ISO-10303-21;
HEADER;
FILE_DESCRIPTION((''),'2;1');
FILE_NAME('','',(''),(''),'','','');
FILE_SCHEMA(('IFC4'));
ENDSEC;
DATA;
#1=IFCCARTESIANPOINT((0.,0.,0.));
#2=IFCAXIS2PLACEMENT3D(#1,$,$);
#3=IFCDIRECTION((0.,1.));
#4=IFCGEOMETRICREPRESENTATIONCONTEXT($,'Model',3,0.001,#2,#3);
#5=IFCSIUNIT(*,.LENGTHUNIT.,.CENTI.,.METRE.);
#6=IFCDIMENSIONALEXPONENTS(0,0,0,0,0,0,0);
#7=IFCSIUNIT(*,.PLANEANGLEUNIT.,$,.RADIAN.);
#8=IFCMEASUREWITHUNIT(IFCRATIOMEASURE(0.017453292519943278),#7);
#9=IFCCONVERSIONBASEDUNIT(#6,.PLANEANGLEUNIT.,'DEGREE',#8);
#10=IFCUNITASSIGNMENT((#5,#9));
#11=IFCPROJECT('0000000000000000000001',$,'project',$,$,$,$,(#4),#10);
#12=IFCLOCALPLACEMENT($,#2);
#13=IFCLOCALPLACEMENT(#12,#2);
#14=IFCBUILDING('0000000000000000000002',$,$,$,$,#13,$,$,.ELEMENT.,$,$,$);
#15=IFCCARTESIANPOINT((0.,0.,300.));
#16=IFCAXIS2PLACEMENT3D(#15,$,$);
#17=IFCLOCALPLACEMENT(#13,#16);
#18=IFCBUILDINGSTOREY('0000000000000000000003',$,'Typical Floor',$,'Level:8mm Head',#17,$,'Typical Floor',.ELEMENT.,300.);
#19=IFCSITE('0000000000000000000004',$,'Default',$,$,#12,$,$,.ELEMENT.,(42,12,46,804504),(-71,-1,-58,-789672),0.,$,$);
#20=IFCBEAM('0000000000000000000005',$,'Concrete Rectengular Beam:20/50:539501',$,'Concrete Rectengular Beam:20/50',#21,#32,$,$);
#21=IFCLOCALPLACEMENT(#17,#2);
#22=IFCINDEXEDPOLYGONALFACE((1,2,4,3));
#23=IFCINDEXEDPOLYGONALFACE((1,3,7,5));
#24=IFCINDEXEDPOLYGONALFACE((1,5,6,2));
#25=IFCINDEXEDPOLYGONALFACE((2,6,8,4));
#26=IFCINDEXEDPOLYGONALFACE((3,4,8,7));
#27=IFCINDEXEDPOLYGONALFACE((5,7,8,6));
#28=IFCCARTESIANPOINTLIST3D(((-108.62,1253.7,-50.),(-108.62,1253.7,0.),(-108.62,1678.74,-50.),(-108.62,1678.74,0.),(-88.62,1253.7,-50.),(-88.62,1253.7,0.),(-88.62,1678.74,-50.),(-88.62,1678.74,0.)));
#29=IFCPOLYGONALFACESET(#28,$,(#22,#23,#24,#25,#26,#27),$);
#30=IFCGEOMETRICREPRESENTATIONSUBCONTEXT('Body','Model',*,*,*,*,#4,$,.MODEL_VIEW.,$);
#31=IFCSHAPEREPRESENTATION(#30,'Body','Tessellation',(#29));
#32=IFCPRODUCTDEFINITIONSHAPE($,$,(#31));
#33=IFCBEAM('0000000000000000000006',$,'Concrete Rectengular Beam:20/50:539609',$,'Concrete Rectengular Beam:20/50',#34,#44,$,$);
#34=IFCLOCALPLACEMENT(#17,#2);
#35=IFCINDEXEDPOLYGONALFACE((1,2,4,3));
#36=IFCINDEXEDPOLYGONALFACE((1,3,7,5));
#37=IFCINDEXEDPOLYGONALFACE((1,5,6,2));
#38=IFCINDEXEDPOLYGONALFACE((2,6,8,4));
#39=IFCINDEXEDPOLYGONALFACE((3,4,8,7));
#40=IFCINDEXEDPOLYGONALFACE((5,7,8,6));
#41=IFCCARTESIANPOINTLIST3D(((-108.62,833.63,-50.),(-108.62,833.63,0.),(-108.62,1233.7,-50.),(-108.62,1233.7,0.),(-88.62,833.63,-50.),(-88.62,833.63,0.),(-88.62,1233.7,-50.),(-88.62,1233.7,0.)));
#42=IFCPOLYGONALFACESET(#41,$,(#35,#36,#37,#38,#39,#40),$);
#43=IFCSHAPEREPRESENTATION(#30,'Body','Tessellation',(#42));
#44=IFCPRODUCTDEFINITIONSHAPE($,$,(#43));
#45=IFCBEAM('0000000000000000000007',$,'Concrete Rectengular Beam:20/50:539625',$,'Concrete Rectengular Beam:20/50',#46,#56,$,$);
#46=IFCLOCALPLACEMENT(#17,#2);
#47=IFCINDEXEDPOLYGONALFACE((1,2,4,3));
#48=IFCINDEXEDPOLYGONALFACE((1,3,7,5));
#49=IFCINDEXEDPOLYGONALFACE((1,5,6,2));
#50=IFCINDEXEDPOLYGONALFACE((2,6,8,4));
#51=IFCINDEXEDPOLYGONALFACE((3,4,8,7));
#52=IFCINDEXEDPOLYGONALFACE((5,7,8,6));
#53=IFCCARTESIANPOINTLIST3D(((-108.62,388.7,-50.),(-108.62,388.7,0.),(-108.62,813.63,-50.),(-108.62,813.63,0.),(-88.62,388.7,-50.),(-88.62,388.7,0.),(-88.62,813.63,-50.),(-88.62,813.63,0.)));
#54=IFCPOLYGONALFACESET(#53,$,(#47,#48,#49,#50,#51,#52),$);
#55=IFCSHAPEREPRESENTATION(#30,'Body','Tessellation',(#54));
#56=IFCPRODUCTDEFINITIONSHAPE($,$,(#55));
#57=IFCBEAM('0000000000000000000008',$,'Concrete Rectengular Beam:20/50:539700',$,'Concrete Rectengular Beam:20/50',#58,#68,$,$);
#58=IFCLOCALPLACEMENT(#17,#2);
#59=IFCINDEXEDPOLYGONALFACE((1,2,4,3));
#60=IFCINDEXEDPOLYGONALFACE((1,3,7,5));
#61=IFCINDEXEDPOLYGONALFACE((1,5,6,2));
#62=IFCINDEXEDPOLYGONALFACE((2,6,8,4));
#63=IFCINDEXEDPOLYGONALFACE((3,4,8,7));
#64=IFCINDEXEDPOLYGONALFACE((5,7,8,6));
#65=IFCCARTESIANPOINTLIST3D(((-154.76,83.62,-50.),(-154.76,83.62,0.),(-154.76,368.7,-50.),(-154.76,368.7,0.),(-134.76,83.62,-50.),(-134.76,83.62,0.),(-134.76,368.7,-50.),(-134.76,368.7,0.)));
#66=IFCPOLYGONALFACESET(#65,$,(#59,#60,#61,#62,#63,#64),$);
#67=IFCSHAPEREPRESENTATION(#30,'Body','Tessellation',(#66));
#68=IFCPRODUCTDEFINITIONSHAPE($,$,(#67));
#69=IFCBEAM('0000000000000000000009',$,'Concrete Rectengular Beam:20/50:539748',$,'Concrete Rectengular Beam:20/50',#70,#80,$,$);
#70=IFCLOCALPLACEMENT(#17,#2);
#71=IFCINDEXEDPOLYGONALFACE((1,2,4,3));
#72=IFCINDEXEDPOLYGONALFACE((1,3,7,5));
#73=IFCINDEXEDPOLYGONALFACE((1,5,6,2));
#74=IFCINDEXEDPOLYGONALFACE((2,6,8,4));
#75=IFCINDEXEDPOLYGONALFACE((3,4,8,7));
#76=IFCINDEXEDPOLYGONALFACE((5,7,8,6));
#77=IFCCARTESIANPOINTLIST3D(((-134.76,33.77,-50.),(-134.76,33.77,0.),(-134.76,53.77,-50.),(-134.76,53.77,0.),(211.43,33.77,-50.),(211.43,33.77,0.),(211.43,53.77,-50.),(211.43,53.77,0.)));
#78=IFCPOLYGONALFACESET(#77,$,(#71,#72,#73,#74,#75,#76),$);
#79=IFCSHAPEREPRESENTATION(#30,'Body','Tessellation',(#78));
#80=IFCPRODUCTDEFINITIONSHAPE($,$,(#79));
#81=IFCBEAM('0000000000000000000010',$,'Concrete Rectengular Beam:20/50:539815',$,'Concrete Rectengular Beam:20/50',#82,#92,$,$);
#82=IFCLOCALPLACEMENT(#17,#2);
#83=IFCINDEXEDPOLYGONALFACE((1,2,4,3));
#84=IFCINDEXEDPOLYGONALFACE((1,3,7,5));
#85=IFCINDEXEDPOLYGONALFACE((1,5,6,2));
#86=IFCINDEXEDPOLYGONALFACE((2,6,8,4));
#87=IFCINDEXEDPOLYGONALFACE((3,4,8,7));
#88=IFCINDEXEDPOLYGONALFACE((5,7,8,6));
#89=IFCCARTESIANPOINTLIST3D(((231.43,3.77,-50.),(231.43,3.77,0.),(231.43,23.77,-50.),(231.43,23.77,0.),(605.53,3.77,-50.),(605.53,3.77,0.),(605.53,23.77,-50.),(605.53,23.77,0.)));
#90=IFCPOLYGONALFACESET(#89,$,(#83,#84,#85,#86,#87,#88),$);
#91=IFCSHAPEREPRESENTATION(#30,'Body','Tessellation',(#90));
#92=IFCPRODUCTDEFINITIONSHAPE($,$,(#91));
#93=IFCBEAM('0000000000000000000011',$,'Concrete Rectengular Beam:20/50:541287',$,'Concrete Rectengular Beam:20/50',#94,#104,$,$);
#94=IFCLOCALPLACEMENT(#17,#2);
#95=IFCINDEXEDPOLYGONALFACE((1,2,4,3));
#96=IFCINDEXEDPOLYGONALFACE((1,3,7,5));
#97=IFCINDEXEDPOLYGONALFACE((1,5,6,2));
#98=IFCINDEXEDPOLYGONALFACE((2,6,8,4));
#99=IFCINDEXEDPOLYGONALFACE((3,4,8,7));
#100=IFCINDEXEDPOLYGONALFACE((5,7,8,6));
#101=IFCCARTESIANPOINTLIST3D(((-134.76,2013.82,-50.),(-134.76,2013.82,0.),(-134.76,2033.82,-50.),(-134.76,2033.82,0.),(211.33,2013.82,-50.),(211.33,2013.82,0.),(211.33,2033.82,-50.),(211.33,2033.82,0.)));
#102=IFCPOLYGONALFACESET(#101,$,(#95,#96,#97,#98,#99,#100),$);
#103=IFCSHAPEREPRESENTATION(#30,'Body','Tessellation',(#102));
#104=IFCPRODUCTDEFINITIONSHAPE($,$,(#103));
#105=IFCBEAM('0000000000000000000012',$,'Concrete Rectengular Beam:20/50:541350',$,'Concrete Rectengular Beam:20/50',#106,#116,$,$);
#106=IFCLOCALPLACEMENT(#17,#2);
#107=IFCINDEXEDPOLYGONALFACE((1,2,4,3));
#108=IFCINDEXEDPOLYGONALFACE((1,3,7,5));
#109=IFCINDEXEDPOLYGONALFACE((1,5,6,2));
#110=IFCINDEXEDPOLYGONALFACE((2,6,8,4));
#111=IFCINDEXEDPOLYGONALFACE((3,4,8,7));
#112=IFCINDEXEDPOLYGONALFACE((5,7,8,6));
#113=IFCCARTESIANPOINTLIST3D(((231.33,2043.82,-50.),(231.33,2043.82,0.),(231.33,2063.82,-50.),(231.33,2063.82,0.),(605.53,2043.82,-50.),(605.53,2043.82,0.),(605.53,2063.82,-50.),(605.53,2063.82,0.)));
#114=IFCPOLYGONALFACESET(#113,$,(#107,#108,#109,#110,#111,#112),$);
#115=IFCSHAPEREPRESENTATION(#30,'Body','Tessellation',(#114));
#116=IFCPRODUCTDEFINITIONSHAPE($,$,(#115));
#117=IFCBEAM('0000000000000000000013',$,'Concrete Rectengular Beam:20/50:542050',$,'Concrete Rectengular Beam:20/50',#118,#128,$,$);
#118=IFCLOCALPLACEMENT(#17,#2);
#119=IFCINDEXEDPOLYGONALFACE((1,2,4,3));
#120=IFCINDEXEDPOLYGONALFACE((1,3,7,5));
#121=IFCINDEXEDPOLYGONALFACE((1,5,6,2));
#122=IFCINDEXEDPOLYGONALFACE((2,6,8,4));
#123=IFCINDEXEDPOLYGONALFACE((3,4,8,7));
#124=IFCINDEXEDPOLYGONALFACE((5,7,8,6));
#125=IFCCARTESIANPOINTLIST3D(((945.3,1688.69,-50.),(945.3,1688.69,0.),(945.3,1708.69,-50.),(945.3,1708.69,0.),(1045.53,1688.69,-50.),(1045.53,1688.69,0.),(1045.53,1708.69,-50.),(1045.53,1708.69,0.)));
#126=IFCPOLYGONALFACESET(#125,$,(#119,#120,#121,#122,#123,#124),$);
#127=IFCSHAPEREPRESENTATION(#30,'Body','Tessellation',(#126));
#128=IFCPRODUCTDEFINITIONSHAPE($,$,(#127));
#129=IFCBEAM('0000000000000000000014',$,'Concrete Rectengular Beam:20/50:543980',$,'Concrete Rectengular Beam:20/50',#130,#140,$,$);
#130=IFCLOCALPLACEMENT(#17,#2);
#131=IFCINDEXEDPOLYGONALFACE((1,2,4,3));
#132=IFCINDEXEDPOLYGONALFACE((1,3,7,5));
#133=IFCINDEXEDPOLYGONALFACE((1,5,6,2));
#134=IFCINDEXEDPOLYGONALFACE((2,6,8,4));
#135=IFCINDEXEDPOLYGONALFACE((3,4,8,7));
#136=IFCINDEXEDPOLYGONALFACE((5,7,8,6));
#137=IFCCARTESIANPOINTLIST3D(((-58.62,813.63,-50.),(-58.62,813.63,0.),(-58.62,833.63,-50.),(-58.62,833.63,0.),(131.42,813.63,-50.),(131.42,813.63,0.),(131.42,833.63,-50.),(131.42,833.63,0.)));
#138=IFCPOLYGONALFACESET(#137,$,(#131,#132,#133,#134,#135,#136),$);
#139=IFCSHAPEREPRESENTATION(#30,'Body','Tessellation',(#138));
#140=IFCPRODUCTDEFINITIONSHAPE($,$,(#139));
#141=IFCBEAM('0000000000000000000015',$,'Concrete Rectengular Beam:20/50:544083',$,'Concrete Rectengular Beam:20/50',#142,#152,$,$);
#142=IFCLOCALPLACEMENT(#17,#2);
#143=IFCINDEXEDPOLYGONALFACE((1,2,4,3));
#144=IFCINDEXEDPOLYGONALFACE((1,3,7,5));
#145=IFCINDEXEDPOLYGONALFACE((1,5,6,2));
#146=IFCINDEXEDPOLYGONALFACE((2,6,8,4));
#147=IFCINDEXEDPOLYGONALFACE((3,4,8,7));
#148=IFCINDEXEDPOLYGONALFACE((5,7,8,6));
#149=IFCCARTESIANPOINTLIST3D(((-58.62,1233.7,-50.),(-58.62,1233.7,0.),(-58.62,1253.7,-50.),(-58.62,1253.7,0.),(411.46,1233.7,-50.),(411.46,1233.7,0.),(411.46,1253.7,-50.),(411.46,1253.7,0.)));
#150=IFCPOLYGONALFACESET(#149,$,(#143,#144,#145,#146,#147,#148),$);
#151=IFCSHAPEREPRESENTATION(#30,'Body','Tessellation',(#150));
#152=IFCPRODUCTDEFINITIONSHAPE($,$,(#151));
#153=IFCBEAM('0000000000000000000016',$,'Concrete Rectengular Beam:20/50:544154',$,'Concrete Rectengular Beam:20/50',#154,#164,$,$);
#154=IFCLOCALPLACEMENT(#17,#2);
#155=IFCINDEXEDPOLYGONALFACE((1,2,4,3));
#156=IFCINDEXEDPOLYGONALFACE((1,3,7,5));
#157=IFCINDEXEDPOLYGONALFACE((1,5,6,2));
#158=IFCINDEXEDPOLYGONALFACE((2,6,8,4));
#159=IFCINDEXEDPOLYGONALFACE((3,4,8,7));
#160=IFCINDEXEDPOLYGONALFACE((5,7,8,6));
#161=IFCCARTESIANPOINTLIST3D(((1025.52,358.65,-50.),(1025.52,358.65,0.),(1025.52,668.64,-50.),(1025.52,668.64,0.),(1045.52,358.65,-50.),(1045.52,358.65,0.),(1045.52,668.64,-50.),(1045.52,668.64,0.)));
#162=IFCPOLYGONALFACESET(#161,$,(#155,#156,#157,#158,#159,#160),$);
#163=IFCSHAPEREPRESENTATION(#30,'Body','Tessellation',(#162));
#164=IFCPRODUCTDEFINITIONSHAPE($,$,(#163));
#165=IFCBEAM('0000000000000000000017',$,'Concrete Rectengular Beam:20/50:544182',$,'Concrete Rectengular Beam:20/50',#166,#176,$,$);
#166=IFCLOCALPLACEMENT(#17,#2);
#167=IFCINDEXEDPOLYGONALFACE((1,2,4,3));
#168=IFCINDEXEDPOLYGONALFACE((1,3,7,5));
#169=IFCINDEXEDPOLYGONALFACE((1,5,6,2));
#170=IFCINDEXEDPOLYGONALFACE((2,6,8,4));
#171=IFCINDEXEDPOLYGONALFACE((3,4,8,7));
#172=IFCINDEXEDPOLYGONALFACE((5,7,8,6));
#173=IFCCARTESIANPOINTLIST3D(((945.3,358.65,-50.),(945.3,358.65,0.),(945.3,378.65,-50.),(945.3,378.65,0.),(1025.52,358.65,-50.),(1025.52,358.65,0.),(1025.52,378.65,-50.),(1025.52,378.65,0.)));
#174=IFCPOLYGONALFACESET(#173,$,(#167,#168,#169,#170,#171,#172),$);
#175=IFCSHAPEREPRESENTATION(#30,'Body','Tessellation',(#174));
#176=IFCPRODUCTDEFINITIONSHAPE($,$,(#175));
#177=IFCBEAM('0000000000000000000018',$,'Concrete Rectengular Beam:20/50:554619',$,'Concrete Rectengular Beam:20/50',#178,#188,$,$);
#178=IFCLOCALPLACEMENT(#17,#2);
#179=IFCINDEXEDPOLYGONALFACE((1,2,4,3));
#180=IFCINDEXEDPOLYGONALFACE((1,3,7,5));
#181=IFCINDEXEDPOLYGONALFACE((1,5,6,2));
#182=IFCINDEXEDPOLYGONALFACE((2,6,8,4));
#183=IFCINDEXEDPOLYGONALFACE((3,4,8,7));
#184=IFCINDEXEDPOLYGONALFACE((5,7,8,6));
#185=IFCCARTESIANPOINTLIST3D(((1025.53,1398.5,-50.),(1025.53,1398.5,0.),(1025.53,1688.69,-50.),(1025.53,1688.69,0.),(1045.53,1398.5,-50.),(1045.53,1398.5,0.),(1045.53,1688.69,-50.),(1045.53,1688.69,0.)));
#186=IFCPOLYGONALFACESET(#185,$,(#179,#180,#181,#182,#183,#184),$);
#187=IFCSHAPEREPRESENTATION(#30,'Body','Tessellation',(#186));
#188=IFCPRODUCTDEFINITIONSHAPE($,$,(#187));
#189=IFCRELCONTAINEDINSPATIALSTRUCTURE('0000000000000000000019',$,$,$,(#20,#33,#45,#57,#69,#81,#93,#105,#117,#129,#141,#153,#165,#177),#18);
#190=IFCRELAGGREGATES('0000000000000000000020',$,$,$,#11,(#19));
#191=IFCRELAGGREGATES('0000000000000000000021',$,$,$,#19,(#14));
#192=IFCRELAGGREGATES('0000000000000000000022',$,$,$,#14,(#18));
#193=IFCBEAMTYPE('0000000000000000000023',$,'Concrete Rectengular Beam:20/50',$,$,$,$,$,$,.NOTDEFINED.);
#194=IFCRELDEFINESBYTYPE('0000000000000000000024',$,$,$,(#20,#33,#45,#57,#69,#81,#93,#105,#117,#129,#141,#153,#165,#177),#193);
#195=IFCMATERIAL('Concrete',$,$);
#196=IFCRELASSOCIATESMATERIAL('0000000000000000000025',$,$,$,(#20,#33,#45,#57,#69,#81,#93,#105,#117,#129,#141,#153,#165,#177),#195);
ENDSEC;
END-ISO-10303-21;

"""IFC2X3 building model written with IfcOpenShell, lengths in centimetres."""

from ifc_helpers import new_model, entity, si_unit, converted_unit, direction, frame, frame_2d, origin, place, context, subcontext, project, spatial, rectangle, extrude, material, type_object, element, save


model = new_model("IFC2X3")

# Units and contexts
model_context = context("Model", 3, precision=0.001, world=origin(), true_north=direction((0.0, 1.0)))
body_context = subcontext(model_context, "Body", "Model", "MODEL_VIEW")
ifc_project = project(units=[si_unit("LENGTHUNIT", "METRE", prefix="CENTI"), converted_unit("PLANEANGLEUNIT", "DEGREE", entity("IfcRatioMeasure", 0.017453292519943278), si_unit("PLANEANGLEUNIT", "RADIAN"), dimensions=[0, 0, 0, 0, 0, 0, 0])], contexts=[model_context])

# Site, building, storey
site_placement = place(None, origin())
site = spatial("IfcSite", under=ifc_project, at=site_placement, Name="Default", CompositionType="ELEMENT", RefLatitude=(42, 12, 46, 804504), RefLongitude=(-71, -1, -58, -789672), RefElevation=0.0)
building_placement = place(site_placement, origin())
building = spatial("IfcBuilding", under=site, at=building_placement, CompositionType="ELEMENT")
storey_placement = place(building_placement, frame((0.0, 0.0, 300.0)))
storey = spatial("IfcBuildingStorey", under=building, at=storey_placement, Name="Typical Floor", ObjectType="Level:8mm Head", LongName="Typical Floor", CompositionType="ELEMENT", Elevation=300.0)

# Beams
ifc_material = material(Name="Concrete")
beam_type_1 = type_object("IfcBeamType", Name="Concrete Rectengular Beam:20/50", PredefinedType="NOTDEFINED")
beam_1_placement = place(storey_placement, frame((-108.62, 1243.7, 0.0), z_axis=(0.0, 0.0, 1.0), x_axis=(0.0, 1.0, 0.0)))
element("IfcBeam", 1, at=beam_1_placement, inside=storey, type_object=beam_type_1, material=ifc_material, Name="Concrete Rectengular Beam:20/50:539501", ObjectType="Concrete Rectengular Beam:20/50", context=body_context, shape_type="SweptSolid", body=[
    extrude(rectangle(XDim=50.0, YDim=20.0, at=frame_2d((0.0, 0.0), x_axis=(1.0, 0.0))), frame((10.0, -10.0, -25.0), z_axis=(1.0, 0.0, 0.0), x_axis=(0.0, 0.0, -1.0)), (0.0, 0.0, 1.0), 425.04),
])
beam_2_placement = place(storey_placement, frame((-88.62, 1243.7, 0.0), z_axis=(0.0, 0.0, 1.0), x_axis=(0.0, -1.0, 0.0)))
element("IfcBeam", 2, at=beam_2_placement, inside=storey, type_object=beam_type_1, material=ifc_material, Name="Concrete Rectengular Beam:20/50:539609", ObjectType="Concrete Rectengular Beam:20/50", context=body_context, shape_type="SweptSolid", body=[
    extrude(rectangle(XDim=50.0, YDim=20.0, at=frame_2d((0.0, 0.0), x_axis=(1.0, 0.0))), frame((10.0, -10.0, -25.0), z_axis=(1.0, 0.0, 0.0), x_axis=(0.0, 0.0, -1.0)), (0.0, 0.0, 1.0), 400.07),
])
beam_3_placement = place(storey_placement, frame((-88.62, 823.63, 0.0), z_axis=(0.0, 0.0, 1.0), x_axis=(0.0, -1.0, 0.0)))
element("IfcBeam", 3, at=beam_3_placement, inside=storey, type_object=beam_type_1, material=ifc_material, Name="Concrete Rectengular Beam:20/50:539625", ObjectType="Concrete Rectengular Beam:20/50", context=body_context, shape_type="SweptSolid", body=[
    extrude(rectangle(XDim=50.0, YDim=20.0, at=frame_2d((0.0, 0.0), x_axis=(1.0, 0.0))), frame((10.0, -10.0, -25.0), z_axis=(1.0, 0.0, 0.0), x_axis=(0.0, 0.0, -1.0)), (0.0, 0.0, 1.0), 424.94),
])
beam_4_placement = place(storey_placement, frame((-144.76, 58.62, 0.0), z_axis=(0.0, 0.0, 1.0), x_axis=(0.0, 1.0, 0.0)))
element("IfcBeam", 4, at=beam_4_placement, inside=storey, type_object=beam_type_1, material=ifc_material, Name="Concrete Rectengular Beam:20/50:539700", ObjectType="Concrete Rectengular Beam:20/50", context=body_context, shape_type="SweptSolid", body=[
    extrude(rectangle(XDim=50.0, YDim=20.0, at=frame_2d((0.0, 0.0), x_axis=(1.0, 0.0))), frame((25.0, 0.0, -25.0), z_axis=(1.0, 0.0, 0.0), x_axis=(0.0, 0.0, -1.0)), (0.0, 0.0, 1.0), 285.08),
])
beam_5_placement = place(storey_placement, frame((221.43, 33.77, 0.0), z_axis=(0.0, 0.0, 1.0), x_axis=(-1.0, 0.0, 0.0)))
element("IfcBeam", 5, at=beam_5_placement, inside=storey, type_object=beam_type_1, material=ifc_material, Name="Concrete Rectengular Beam:20/50:539748", ObjectType="Concrete Rectengular Beam:20/50", context=body_context, shape_type="SweptSolid", body=[
    extrude(rectangle(XDim=50.0, YDim=20.0, at=frame_2d((0.0, 0.0), x_axis=(1.0, 0.0))), frame((10.0, -10.0, -25.0), z_axis=(1.0, 0.0, 0.0), x_axis=(0.0, 0.0, -1.0)), (0.0, 0.0, 1.0), 346.19),
])
beam_6_placement = place(storey_placement, frame((221.43, 23.77, 0.0)))
element("IfcBeam", 6, at=beam_6_placement, inside=storey, type_object=beam_type_1, material=ifc_material, Name="Concrete Rectengular Beam:20/50:539815", ObjectType="Concrete Rectengular Beam:20/50", context=body_context, shape_type="SweptSolid", body=[
    extrude(rectangle(XDim=50.0, YDim=20.0, at=frame_2d((0.0, 0.0), x_axis=(1.0, 0.0))), frame((10.0, -10.0, -25.0), z_axis=(1.0, 0.0, 0.0), x_axis=(0.0, 0.0, -1.0)), (0.0, 0.0, 1.0), 374.1),
])
beam_7_placement = place(storey_placement, frame((-144.76, 2033.82, 0.0)))
element("IfcBeam", 7, at=beam_7_placement, inside=storey, type_object=beam_type_1, material=ifc_material, Name="Concrete Rectengular Beam:20/50:541287", ObjectType="Concrete Rectengular Beam:20/50", context=body_context, shape_type="SweptSolid", body=[
    extrude(rectangle(XDim=50.0, YDim=20.0, at=frame_2d((0.0, 0.0), x_axis=(1.0, 0.0))), frame((10.0, -10.0, -25.0), z_axis=(1.0, 0.0, 0.0), x_axis=(0.0, 0.0, -1.0)), (0.0, 0.0, 1.0), 346.09),
])
beam_8_placement = place(storey_placement, frame((221.33, 2063.82, 0.0)))
element("IfcBeam", 8, at=beam_8_placement, inside=storey, type_object=beam_type_1, material=ifc_material, Name="Concrete Rectengular Beam:20/50:541350", ObjectType="Concrete Rectengular Beam:20/50", context=body_context, shape_type="SweptSolid", body=[
    extrude(rectangle(XDim=50.0, YDim=20.0, at=frame_2d((0.0, 0.0), x_axis=(1.0, 0.0))), frame((10.0, -10.0, -25.0), z_axis=(1.0, 0.0, 0.0), x_axis=(0.0, 0.0, -1.0)), (0.0, 0.0, 1.0), 374.21),
])
beam_9_placement = place(storey_placement, frame((1025.53, 1698.69, 0.0), z_axis=(0.0, 0.0, 1.0), x_axis=(-1.0, 0.0, 0.0)))
element("IfcBeam", 9, at=beam_9_placement, inside=storey, type_object=beam_type_1, material=ifc_material, Name="Concrete Rectengular Beam:20/50:542050", ObjectType="Concrete Rectengular Beam:20/50", context=body_context, shape_type="SweptSolid", body=[
    extrude(rectangle(XDim=50.0, YDim=20.0, at=frame_2d((0.0, 0.0), x_axis=(1.0, 0.0))), frame((-20.0, 0.0, -25.0), z_axis=(1.0, 0.0, 0.0), x_axis=(0.0, 0.0, -1.0)), (0.0, 0.0, 1.0), 100.23),
])
beam_10_placement = place(storey_placement, frame((-83.62, 823.63, 0.0)))
element("IfcBeam", 10, at=beam_10_placement, inside=storey, type_object=beam_type_1, material=ifc_material, Name="Concrete Rectengular Beam:20/50:543980", ObjectType="Concrete Rectengular Beam:20/50", context=body_context, shape_type="SweptSolid", body=[
    extrude(rectangle(XDim=50.0, YDim=20.0, at=frame_2d((0.0, 0.0), x_axis=(1.0, 0.0))), frame((25.0, 0.0, -25.0), z_axis=(1.0, 0.0, 0.0), x_axis=(0.0, 0.0, -1.0)), (0.0, 0.0, 1.0), 190.04),
])
beam_11_placement = place(storey_placement, frame((-83.62, 1243.7, 0.0)))
element("IfcBeam", 11, at=beam_11_placement, inside=storey, type_object=beam_type_1, material=ifc_material, Name="Concrete Rectengular Beam:20/50:544083", ObjectType="Concrete Rectengular Beam:20/50", context=body_context, shape_type="SweptSolid", body=[
    extrude(rectangle(XDim=50.0, YDim=20.0, at=frame_2d((0.0, 0.0), x_axis=(1.0, 0.0))), frame((25.0, 0.0, -25.0), z_axis=(1.0, 0.0, 0.0), x_axis=(0.0, 0.0, -1.0)), (0.0, 0.0, 1.0), 470.08),
])
beam_12_placement = place(storey_placement, frame((1035.52, 693.64, 0.0), z_axis=(0.0, 0.0, 1.0), x_axis=(0.0, -1.0, 0.0)))
element("IfcBeam", 12, at=beam_12_placement, inside=storey, type_object=beam_type_1, material=ifc_material, Name="Concrete Rectengular Beam:20/50:544154", ObjectType="Concrete Rectengular Beam:20/50", context=body_context, shape_type="SweptSolid", body=[
    extrude(rectangle(XDim=50.0, YDim=20.0, at=frame_2d((0.0, 0.0), x_axis=(1.0, 0.0))), frame((25.0, 0.0, -25.0), z_axis=(1.0, 0.0, 0.0), x_axis=(0.0, 0.0, -1.0)), (0.0, 0.0, 1.0), 309.99),
])
beam_13_placement = place(storey_placement, frame((1035.52, 368.65, 0.0), z_axis=(0.0, 0.0, 1.0), x_axis=(-1.0, 0.0, 0.0)))
element("IfcBeam", 13, at=beam_13_placement, inside=storey, type_object=beam_type_1, material=ifc_material, Name="Concrete Rectengular Beam:20/50:544182", ObjectType="Concrete Rectengular Beam:20/50", context=body_context, shape_type="SweptSolid", body=[
    extrude(rectangle(XDim=50.0, YDim=20.0, at=frame_2d((0.0, 0.0), x_axis=(1.0, 0.0))), frame((10.0, 0.0, -25.0), z_axis=(1.0, 0.0, 0.0), x_axis=(0.0, 0.0, -1.0)), (0.0, 0.0, 1.0), 80.22),
])
beam_14_placement = place(storey_placement, frame((1025.53, 1373.5, 0.0), z_axis=(0.0, 0.0, 1.0), x_axis=(0.0, 1.0, 0.0)))
element("IfcBeam", 14, at=beam_14_placement, inside=storey, type_object=beam_type_1, material=ifc_material, Name="Concrete Rectengular Beam:20/50:554619", ObjectType="Concrete Rectengular Beam:20/50", context=body_context, shape_type="SweptSolid", body=[
    extrude(rectangle(XDim=50.0, YDim=20.0, at=frame_2d((0.0, 0.0), x_axis=(1.0, 0.0))), frame((25.0, -10.0, -25.0), z_axis=(1.0, 0.0, 0.0), x_axis=(0.0, 0.0, -1.0)), (0.0, 0.0, 1.0), 290.19),
])

save(model, "model.ifc")
